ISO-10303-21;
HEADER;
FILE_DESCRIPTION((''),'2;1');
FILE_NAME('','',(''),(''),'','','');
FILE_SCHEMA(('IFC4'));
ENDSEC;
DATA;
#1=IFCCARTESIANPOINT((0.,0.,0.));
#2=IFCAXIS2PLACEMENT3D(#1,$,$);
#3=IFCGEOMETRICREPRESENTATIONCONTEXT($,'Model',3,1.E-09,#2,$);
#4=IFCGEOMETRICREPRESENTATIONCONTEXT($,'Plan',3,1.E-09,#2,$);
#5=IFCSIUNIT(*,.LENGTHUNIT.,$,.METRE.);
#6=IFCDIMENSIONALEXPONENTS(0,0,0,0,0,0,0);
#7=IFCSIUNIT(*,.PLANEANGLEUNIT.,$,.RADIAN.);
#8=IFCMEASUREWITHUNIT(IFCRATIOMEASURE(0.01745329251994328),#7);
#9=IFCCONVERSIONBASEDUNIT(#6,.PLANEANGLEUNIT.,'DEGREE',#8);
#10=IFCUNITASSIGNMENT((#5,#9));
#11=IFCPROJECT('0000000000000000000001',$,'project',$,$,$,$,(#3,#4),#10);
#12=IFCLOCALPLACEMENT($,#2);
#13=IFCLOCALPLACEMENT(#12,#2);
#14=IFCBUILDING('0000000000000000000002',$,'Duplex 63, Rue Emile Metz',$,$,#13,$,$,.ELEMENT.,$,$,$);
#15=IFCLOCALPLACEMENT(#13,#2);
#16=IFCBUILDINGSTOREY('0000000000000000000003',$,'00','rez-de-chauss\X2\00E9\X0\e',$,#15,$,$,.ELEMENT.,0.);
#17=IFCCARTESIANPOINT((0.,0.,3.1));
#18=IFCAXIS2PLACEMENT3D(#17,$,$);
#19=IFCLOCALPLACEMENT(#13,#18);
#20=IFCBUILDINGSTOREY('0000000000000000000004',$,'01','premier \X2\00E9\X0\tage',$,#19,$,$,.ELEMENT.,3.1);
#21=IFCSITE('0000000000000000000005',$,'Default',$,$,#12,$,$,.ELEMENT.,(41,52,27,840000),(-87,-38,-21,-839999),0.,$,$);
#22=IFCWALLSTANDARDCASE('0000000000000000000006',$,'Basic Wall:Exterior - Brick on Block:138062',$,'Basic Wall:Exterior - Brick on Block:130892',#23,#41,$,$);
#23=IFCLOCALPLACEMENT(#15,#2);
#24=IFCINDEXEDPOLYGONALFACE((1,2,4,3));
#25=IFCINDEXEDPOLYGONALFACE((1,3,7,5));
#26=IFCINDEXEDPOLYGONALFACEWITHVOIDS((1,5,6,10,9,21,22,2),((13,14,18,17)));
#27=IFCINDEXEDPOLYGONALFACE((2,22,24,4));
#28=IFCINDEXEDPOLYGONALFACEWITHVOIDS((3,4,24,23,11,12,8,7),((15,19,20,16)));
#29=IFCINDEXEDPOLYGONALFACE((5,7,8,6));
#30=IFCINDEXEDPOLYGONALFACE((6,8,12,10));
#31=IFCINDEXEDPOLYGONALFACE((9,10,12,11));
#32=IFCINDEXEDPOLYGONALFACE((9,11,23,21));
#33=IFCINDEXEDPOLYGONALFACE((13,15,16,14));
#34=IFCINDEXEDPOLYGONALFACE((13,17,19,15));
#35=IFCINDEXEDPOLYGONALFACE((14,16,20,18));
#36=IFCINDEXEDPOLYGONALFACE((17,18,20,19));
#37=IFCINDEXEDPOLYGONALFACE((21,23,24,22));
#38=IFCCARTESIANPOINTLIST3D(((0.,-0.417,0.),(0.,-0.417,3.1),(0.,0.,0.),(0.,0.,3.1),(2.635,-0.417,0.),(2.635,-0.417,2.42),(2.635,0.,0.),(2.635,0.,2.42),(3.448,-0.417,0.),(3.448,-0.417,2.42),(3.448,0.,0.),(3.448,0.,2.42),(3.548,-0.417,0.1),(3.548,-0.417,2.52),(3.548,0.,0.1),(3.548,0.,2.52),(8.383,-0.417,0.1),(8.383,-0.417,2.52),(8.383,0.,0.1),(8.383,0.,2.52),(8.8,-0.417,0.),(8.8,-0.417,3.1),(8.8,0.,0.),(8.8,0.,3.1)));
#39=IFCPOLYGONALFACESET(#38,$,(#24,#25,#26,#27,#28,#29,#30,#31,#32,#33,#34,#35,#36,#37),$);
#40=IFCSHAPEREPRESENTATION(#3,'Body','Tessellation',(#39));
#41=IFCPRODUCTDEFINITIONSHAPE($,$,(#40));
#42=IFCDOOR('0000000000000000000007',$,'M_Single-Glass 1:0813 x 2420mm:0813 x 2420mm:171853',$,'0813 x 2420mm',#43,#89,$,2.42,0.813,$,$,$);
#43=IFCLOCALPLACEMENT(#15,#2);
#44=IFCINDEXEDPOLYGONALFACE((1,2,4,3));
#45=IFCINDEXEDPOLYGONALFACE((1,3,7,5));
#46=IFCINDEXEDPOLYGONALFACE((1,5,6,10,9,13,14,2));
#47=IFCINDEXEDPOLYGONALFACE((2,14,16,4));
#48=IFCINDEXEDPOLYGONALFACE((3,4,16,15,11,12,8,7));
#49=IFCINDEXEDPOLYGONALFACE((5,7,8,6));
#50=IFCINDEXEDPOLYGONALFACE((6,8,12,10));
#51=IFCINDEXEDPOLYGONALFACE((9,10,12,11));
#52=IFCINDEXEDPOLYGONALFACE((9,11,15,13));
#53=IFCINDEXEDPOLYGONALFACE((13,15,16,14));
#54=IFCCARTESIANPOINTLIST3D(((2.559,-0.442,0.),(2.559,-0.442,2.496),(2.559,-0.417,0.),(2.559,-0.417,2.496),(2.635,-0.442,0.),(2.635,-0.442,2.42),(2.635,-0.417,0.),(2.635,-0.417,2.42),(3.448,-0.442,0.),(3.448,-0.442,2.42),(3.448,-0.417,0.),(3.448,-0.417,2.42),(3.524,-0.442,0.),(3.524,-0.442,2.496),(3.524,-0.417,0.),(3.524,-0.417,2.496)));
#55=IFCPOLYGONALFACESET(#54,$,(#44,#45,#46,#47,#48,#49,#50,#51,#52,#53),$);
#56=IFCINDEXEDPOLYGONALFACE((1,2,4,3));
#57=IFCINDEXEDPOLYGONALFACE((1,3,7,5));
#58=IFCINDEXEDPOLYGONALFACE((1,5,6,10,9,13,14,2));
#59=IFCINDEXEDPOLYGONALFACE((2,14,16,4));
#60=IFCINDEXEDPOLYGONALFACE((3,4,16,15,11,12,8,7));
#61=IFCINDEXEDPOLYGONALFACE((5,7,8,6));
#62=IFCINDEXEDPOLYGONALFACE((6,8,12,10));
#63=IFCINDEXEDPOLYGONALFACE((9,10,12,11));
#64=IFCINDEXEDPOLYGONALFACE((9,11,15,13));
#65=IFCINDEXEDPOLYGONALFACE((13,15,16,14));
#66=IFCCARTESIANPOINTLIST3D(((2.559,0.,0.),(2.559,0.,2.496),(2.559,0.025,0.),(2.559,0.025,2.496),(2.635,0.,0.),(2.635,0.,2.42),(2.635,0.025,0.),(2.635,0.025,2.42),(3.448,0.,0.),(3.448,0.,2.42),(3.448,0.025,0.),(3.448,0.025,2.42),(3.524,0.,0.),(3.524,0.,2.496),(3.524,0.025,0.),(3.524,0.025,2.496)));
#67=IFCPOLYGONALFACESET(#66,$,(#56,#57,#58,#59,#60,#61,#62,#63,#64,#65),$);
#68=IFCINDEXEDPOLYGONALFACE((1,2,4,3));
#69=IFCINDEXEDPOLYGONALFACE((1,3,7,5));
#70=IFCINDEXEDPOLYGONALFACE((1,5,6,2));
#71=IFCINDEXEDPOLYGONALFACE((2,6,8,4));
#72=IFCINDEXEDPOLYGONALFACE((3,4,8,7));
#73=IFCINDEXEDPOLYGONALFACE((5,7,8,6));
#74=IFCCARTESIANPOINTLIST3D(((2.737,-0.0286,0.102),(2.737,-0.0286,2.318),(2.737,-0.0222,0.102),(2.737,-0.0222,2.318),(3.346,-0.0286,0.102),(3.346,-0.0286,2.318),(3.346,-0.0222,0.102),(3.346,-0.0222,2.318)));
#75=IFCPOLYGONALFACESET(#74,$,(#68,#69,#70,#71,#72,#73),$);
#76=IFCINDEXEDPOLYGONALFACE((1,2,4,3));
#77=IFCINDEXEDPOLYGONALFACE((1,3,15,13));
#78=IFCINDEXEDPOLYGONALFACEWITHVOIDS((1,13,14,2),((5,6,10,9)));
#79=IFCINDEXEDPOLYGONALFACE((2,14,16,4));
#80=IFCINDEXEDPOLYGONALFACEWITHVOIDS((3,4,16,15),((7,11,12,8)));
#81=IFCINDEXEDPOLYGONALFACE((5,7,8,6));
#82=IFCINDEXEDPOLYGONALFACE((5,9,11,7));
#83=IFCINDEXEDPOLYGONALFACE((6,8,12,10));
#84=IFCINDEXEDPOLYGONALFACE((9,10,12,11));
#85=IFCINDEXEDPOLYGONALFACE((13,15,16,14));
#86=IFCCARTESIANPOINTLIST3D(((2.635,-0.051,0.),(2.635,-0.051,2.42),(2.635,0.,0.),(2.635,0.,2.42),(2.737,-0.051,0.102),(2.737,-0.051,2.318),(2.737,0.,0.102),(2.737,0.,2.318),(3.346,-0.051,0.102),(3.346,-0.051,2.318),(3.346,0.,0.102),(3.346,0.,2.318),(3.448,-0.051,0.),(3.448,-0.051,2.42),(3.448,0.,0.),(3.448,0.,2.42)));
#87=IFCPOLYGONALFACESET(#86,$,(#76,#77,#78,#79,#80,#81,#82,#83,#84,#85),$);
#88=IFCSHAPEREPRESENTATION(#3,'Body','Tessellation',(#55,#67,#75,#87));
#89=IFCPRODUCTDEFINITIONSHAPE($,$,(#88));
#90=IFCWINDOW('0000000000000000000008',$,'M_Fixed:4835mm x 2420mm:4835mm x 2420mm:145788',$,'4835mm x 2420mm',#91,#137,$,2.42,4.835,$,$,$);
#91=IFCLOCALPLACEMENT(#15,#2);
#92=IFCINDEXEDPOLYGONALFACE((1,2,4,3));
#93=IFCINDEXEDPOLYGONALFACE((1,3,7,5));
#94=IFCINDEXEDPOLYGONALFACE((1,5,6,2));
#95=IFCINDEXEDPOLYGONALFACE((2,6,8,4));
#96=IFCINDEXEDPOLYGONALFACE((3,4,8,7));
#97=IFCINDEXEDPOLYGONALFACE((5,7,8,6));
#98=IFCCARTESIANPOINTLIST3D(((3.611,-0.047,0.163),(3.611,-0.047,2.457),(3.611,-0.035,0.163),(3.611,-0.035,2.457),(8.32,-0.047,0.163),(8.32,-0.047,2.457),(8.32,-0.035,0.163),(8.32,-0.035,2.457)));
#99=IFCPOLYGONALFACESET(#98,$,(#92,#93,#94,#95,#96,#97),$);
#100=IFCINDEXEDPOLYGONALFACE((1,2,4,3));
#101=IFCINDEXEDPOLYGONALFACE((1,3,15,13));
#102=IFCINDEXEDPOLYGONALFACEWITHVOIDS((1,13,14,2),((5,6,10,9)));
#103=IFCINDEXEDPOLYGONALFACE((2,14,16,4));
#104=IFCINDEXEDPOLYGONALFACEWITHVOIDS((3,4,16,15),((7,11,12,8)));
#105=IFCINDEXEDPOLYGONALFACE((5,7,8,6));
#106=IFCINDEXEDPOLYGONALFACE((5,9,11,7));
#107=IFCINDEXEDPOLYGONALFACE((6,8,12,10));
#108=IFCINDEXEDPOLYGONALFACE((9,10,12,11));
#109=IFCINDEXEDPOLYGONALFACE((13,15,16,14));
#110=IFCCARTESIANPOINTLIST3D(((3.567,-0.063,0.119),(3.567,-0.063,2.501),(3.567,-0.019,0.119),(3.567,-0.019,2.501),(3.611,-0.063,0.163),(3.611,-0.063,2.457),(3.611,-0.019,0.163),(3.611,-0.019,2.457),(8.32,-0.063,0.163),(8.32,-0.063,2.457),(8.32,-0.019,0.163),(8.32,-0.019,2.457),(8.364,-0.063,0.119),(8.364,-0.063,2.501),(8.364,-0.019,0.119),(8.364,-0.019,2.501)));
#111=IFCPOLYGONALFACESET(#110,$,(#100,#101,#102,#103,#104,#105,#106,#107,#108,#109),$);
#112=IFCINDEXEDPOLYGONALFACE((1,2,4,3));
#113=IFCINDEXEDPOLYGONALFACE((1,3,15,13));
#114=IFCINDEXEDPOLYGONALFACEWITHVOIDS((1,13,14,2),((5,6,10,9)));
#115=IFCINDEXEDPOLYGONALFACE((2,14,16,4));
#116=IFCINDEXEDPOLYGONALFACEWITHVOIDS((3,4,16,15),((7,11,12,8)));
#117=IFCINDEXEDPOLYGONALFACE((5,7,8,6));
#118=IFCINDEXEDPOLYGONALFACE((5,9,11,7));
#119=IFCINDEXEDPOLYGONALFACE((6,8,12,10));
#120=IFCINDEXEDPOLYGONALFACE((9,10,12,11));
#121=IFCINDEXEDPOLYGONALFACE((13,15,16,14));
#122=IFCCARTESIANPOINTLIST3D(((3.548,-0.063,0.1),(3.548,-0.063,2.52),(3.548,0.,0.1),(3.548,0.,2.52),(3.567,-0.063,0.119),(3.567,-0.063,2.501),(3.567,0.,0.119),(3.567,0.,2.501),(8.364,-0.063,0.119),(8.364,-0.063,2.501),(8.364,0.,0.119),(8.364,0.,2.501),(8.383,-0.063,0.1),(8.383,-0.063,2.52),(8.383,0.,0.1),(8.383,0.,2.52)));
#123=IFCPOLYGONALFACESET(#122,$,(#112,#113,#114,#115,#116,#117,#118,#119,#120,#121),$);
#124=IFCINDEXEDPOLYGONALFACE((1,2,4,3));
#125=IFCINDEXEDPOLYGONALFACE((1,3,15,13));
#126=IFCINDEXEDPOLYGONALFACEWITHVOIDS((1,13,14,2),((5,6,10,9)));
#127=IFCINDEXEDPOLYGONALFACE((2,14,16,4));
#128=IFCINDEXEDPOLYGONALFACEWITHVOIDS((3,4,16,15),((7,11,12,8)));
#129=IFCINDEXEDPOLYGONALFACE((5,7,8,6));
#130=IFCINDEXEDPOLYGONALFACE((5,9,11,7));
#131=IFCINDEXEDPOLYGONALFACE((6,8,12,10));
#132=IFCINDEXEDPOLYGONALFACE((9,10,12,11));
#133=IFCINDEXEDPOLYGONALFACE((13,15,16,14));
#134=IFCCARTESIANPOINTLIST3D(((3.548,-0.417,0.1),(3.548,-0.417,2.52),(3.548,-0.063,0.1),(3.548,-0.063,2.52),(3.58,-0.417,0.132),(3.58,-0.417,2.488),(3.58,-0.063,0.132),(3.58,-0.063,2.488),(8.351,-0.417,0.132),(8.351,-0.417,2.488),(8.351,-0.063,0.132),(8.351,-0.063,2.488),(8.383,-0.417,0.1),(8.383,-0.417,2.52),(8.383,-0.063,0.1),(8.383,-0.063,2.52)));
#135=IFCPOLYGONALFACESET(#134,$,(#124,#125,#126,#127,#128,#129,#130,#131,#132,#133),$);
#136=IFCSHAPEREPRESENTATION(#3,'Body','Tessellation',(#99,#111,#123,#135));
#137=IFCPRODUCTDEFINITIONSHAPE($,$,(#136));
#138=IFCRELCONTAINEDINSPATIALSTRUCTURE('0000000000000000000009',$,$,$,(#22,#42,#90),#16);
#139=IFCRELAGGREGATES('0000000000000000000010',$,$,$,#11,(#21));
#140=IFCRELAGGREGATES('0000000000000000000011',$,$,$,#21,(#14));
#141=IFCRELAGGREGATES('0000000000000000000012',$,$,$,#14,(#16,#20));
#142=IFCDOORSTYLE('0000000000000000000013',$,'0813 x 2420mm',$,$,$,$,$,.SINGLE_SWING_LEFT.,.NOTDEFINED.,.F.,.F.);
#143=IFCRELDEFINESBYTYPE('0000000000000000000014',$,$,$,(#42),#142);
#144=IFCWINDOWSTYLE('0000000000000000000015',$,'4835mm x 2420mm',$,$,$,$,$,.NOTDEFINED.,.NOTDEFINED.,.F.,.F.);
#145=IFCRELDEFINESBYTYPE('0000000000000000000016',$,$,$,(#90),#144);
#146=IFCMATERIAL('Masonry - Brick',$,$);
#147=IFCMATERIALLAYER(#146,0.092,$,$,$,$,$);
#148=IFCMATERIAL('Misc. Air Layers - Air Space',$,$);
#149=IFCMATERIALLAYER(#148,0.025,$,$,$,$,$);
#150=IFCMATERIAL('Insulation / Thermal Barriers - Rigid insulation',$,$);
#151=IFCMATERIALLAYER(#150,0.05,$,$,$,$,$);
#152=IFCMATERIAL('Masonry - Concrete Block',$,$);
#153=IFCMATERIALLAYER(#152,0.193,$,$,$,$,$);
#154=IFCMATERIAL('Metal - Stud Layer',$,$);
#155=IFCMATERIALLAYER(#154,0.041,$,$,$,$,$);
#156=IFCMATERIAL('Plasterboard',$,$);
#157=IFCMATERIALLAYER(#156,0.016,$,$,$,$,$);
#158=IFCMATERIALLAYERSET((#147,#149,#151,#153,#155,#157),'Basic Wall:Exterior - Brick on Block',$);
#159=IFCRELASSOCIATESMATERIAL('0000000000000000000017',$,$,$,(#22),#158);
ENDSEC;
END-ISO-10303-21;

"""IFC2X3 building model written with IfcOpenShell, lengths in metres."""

from ifc_helpers import new_model, entity, si_unit, converted_unit, frame, frame_2d, origin, origin_2d_with_axis, place, context, project, spatial, polyline, rectangle, outline, extrude, source, transform, mapped, material, layer, layer_set, layer_usage, type_object, type_shapes, element, fill, save


model = new_model("IFC2X3")

# Units and contexts
model_context = context("Model", 3, precision=1e-09, world=origin())
plan_context = context("Plan", 3, precision=1e-09, world=origin())
ifc_project = project(units=[si_unit("LENGTHUNIT", "METRE"), converted_unit("PLANEANGLEUNIT", "DEGREE", entity("IfcRatioMeasure", 0.01745329251994328), si_unit("PLANEANGLEUNIT", "RADIAN"), dimensions=[0, 0, 0, 0, 0, 0, 0])], contexts=[model_context, plan_context])

# Site, building, storey
site_placement = place(None, origin())
site = spatial("IfcSite", under=ifc_project, at=site_placement, Name="Default", CompositionType="ELEMENT", RefLatitude=(41, 52, 27, 840000), RefLongitude=(-87, -38, -21, -839999), RefElevation=0.0)
building_placement = place(site_placement, origin())
building = spatial("IfcBuilding", under=site, at=building_placement, Name="Duplex 63, Rue Emile Metz", CompositionType="ELEMENT")
storey_1_placement = place(building_placement, origin())
storey_1 = spatial("IfcBuildingStorey", under=building, at=storey_1_placement, Name="00", Description="rez-de-chaussée", CompositionType="ELEMENT", Elevation=0.0)

# Shared definitions
ifc_material_1 = material(Name="Masonry - Brick")
ifc_layer_1 = layer(ifc_material_1, 0.092)
ifc_material_2 = material(Name="Misc. Air Layers - Air Space")
ifc_layer_2 = layer(ifc_material_2, 0.025)
ifc_material_3 = material(Name="Insulation / Thermal Barriers - Rigid insulation")
ifc_layer_3 = layer(ifc_material_3, 0.05)
ifc_material_4 = material(Name="Masonry - Concrete Block")
ifc_layer_4 = layer(ifc_material_4, 0.193)
ifc_material_5 = material(Name="Metal - Stud Layer")
ifc_layer_5 = layer(ifc_material_5, 0.041)
ifc_material_6 = material(Name="Plasterboard")
ifc_layer_6 = layer(ifc_material_6, 0.016)
ifc_layer_set_1 = layer_set([ifc_layer_1, ifc_layer_2, ifc_layer_3, ifc_layer_4, ifc_layer_5, ifc_layer_6], Name="Basic Wall:Exterior - Brick on Block")
ifc_layer_usage_1 = layer_usage(ifc_layer_set_1, "AXIS2", "NEGATIVE", 0.2085)

# Wall, openings, door, window
wall_1_placement = place(storey_1_placement, frame((0.0, -0.2085, 0.0)))
wall_1 = element("IfcWallStandardCase", 1, at=wall_1_placement, inside=storey_1, material=ifc_layer_usage_1, Name="Basic Wall:Exterior - Brick on Block:138062", ObjectType="Basic Wall:Exterior - Brick on Block:130892", context=model_context, shape_type="SweptSolid", body=[
    extrude(rectangle(XDim=8.8, YDim=0.417, at=frame_2d((4.4, 0.0), x_axis=(-1.0, 0.0))), origin(), (0.0, 0.0, 1.0), 3.1),
])
opening_1_placement = place(wall_1_placement, frame((3.548, -0.2085, 0.1)))
opening_1 = element("IfcOpeningElement", 2, at=opening_1_placement, cuts=wall_1, ObjectType="Opening", context=model_context, shape_type="SweptSolid", body=[
    extrude(rectangle(XDim=2.42, YDim=4.835, at=frame_2d((1.21, 2.4175), x_axis=(1.0, 0.0))), frame((0.0, 0.0, 0.0), z_axis=(0.0, 1.0, 0.0), x_axis=(0.0, 0.0, 1.0)), (0.0, 0.0, 1.0), 0.417),
])
opening_2_placement = place(wall_1_placement, frame((2.635, -0.2085, 0.0)))
opening_2 = element("IfcOpeningElement", 3, at=opening_2_placement, cuts=wall_1, ObjectType="Opening", context=model_context, shape_type="SweptSolid", body=[
    extrude(rectangle(XDim=0.813, YDim=2.42, at=frame_2d((1.21, 0.4065), x_axis=(0.0, -1.0))), frame((0.0, 0.0, 0.0), z_axis=(0.0, 1.0, 0.0), x_axis=(0.0, 0.0, 1.0)), (0.0, 0.0, 1.0), 0.417),
])
door_style_1 = type_object("IfcDoorStyle", Name="0813 x 2420mm", ConstructionType="NOTDEFINED", OperationType="SINGLE_SWING_LEFT", ParameterTakesPrecedence=False, Sizeable=False)
shared_shape_1 = source(origin(), model_context, "Body", "SweptSolid", [
    extrude(outline(polyline([(-0.4065, -1.191), (-0.4065, 1.229), (-0.4825, 1.229), (-0.4825, -1.267), (0.4825, -1.267), (0.4825, 1.229), (0.4065, 1.229), (0.4065, -1.191), (-0.4065, -1.191)])), frame((0.4065, 0.0, 1.229), z_axis=(0.0, 1.0, 0.0), x_axis=(1.0, 0.0, 0.0)), (0.0, 0.0, -1.0), 0.025),
    extrude(outline(polyline([(-0.4065, -1.191), (-0.4065, 1.229), (-0.4825, 1.229), (-0.4825, -1.267), (0.4825, -1.267), (0.4825, 1.229), (0.4065, 1.229), (0.4065, -1.191), (-0.4065, -1.191)])), frame((0.4065, 0.442, 1.229), z_axis=(0.0, 1.0, 0.0), x_axis=(1.0, 0.0, 0.0)), (0.0, 0.0, -1.0), 0.025),
    extrude(rectangle(XDim=0.609, YDim=0.0064, at=origin_2d_with_axis()), frame((0.4065, 0.3916, 0.102)), (0.0, 0.0, 1.0), 2.216),
    extrude(outline(polyline([(-1.21, -0.4065), (1.21, -0.4065), (1.21, 0.4065), (-1.21, 0.4065), (-1.21, -0.4065)]), holes=[polyline([(-1.108, 0.3045), (1.108, 0.3045), (1.108, -0.3045), (-1.108, -0.3045), (-1.108, 0.3045)])]), frame((0.4065, 0.417, 1.21), z_axis=(0.0, -1.0, 0.0), x_axis=(0.0, 0.0, -1.0)), (0.0, 0.0, 1.0), 0.051),
])
type_shapes(door_style_1, [shared_shape_1])
door_1_placement = place(opening_2_placement, origin())
door_1 = element("IfcDoor", 4, at=door_1_placement, inside=storey_1, type_object=door_style_1, Name="M_Single-Glass 1:0813 x 2420mm:0813 x 2420mm:171853", ObjectType="0813 x 2420mm", OverallHeight=2.42, OverallWidth=0.813, context=model_context, shape_type="MappedRepresentation", body=[
    mapped(shared_shape_1, transform((0.0, 0.0, 0.0), scale=1.0)),
])
fill(opening_2, door_1)
window_style_1 = type_object("IfcWindowStyle", Name="4835mm x 2420mm", ConstructionType="NOTDEFINED", OperationType="NOTDEFINED", ParameterTakesPrecedence=False, Sizeable=False)
shared_shape_2 = source(origin(), model_context, "Body", "SweptSolid", [
    extrude(rectangle(XDim=0.012, YDim=4.709, at=origin_2d_with_axis()), frame((2.4175, 0.376, 0.063), z_axis=(0.0, 0.0, 1.0), x_axis=(0.0, -1.0, 0.0)), (0.0, 0.0, 1.0), 2.294),
    extrude(outline(polyline([(-2.3985, -1.191), (2.3985, -1.191), (2.3985, 1.191), (-2.3985, 1.191), (-2.3985, -1.191)]), holes=[polyline([(-2.3545, -1.147), (-2.3545, 1.147), (2.3545, 1.147), (2.3545, -1.147), (-2.3545, -1.147)])]), frame((2.4175, 0.354, 1.21), z_axis=(0.0, 1.0, 0.0), x_axis=(1.0, 0.0, 0.0)), (0.0, 0.0, 1.0), 0.044),
    extrude(outline(polyline([(-2.4175, -1.21), (2.4175, -1.21), (2.4175, 1.21), (-2.4175, 1.21), (-2.4175, -1.21)]), holes=[polyline([(-2.3985, -1.191), (-2.3985, 1.191), (2.3985, 1.191), (2.3985, -1.191), (-2.3985, -1.191)])]), frame((2.4175, 0.354, 1.21), z_axis=(0.0, 1.0, 0.0), x_axis=(1.0, 0.0, 0.0)), (0.0, 0.0, 1.0), 0.063),
    extrude(outline(polyline([(-2.4175, -1.21), (2.4175, -1.21), (2.4175, 1.21), (-2.4175, 1.21), (-2.4175, -1.21)]), holes=[polyline([(-2.3855, -1.178), (-2.3855, 1.178), (2.3855, 1.178), (2.3855, -1.178), (-2.3855, -1.178)])]), frame((2.4175, 0.0, 1.21), z_axis=(0.0, 1.0, 0.0), x_axis=(1.0, 0.0, 0.0)), (0.0, 0.0, 1.0), 0.354),
])
type_shapes(window_style_1, [shared_shape_2])
window_1_placement = place(opening_1_placement, origin())
window_1 = element("IfcWindow", 5, at=window_1_placement, inside=storey_1, type_object=window_style_1, Name="M_Fixed:4835mm x 2420mm:4835mm x 2420mm:145788", ObjectType="4835mm x 2420mm", OverallHeight=2.42, OverallWidth=4.835, context=model_context, shape_type="MappedRepresentation", body=[
    mapped(shared_shape_2, transform((0.0, 0.0, 0.0), scale=1.0)),
])
fill(opening_1, window_1)

# Shared definitions
storey_2_placement = place(building_placement, frame((0.0, 0.0, 3.1)))
storey_2 = spatial("IfcBuildingStorey", under=building, at=storey_2_placement, Name="01", Description="premier étage", CompositionType="ELEMENT", Elevation=3.1)

save(model, "model.ifc")
